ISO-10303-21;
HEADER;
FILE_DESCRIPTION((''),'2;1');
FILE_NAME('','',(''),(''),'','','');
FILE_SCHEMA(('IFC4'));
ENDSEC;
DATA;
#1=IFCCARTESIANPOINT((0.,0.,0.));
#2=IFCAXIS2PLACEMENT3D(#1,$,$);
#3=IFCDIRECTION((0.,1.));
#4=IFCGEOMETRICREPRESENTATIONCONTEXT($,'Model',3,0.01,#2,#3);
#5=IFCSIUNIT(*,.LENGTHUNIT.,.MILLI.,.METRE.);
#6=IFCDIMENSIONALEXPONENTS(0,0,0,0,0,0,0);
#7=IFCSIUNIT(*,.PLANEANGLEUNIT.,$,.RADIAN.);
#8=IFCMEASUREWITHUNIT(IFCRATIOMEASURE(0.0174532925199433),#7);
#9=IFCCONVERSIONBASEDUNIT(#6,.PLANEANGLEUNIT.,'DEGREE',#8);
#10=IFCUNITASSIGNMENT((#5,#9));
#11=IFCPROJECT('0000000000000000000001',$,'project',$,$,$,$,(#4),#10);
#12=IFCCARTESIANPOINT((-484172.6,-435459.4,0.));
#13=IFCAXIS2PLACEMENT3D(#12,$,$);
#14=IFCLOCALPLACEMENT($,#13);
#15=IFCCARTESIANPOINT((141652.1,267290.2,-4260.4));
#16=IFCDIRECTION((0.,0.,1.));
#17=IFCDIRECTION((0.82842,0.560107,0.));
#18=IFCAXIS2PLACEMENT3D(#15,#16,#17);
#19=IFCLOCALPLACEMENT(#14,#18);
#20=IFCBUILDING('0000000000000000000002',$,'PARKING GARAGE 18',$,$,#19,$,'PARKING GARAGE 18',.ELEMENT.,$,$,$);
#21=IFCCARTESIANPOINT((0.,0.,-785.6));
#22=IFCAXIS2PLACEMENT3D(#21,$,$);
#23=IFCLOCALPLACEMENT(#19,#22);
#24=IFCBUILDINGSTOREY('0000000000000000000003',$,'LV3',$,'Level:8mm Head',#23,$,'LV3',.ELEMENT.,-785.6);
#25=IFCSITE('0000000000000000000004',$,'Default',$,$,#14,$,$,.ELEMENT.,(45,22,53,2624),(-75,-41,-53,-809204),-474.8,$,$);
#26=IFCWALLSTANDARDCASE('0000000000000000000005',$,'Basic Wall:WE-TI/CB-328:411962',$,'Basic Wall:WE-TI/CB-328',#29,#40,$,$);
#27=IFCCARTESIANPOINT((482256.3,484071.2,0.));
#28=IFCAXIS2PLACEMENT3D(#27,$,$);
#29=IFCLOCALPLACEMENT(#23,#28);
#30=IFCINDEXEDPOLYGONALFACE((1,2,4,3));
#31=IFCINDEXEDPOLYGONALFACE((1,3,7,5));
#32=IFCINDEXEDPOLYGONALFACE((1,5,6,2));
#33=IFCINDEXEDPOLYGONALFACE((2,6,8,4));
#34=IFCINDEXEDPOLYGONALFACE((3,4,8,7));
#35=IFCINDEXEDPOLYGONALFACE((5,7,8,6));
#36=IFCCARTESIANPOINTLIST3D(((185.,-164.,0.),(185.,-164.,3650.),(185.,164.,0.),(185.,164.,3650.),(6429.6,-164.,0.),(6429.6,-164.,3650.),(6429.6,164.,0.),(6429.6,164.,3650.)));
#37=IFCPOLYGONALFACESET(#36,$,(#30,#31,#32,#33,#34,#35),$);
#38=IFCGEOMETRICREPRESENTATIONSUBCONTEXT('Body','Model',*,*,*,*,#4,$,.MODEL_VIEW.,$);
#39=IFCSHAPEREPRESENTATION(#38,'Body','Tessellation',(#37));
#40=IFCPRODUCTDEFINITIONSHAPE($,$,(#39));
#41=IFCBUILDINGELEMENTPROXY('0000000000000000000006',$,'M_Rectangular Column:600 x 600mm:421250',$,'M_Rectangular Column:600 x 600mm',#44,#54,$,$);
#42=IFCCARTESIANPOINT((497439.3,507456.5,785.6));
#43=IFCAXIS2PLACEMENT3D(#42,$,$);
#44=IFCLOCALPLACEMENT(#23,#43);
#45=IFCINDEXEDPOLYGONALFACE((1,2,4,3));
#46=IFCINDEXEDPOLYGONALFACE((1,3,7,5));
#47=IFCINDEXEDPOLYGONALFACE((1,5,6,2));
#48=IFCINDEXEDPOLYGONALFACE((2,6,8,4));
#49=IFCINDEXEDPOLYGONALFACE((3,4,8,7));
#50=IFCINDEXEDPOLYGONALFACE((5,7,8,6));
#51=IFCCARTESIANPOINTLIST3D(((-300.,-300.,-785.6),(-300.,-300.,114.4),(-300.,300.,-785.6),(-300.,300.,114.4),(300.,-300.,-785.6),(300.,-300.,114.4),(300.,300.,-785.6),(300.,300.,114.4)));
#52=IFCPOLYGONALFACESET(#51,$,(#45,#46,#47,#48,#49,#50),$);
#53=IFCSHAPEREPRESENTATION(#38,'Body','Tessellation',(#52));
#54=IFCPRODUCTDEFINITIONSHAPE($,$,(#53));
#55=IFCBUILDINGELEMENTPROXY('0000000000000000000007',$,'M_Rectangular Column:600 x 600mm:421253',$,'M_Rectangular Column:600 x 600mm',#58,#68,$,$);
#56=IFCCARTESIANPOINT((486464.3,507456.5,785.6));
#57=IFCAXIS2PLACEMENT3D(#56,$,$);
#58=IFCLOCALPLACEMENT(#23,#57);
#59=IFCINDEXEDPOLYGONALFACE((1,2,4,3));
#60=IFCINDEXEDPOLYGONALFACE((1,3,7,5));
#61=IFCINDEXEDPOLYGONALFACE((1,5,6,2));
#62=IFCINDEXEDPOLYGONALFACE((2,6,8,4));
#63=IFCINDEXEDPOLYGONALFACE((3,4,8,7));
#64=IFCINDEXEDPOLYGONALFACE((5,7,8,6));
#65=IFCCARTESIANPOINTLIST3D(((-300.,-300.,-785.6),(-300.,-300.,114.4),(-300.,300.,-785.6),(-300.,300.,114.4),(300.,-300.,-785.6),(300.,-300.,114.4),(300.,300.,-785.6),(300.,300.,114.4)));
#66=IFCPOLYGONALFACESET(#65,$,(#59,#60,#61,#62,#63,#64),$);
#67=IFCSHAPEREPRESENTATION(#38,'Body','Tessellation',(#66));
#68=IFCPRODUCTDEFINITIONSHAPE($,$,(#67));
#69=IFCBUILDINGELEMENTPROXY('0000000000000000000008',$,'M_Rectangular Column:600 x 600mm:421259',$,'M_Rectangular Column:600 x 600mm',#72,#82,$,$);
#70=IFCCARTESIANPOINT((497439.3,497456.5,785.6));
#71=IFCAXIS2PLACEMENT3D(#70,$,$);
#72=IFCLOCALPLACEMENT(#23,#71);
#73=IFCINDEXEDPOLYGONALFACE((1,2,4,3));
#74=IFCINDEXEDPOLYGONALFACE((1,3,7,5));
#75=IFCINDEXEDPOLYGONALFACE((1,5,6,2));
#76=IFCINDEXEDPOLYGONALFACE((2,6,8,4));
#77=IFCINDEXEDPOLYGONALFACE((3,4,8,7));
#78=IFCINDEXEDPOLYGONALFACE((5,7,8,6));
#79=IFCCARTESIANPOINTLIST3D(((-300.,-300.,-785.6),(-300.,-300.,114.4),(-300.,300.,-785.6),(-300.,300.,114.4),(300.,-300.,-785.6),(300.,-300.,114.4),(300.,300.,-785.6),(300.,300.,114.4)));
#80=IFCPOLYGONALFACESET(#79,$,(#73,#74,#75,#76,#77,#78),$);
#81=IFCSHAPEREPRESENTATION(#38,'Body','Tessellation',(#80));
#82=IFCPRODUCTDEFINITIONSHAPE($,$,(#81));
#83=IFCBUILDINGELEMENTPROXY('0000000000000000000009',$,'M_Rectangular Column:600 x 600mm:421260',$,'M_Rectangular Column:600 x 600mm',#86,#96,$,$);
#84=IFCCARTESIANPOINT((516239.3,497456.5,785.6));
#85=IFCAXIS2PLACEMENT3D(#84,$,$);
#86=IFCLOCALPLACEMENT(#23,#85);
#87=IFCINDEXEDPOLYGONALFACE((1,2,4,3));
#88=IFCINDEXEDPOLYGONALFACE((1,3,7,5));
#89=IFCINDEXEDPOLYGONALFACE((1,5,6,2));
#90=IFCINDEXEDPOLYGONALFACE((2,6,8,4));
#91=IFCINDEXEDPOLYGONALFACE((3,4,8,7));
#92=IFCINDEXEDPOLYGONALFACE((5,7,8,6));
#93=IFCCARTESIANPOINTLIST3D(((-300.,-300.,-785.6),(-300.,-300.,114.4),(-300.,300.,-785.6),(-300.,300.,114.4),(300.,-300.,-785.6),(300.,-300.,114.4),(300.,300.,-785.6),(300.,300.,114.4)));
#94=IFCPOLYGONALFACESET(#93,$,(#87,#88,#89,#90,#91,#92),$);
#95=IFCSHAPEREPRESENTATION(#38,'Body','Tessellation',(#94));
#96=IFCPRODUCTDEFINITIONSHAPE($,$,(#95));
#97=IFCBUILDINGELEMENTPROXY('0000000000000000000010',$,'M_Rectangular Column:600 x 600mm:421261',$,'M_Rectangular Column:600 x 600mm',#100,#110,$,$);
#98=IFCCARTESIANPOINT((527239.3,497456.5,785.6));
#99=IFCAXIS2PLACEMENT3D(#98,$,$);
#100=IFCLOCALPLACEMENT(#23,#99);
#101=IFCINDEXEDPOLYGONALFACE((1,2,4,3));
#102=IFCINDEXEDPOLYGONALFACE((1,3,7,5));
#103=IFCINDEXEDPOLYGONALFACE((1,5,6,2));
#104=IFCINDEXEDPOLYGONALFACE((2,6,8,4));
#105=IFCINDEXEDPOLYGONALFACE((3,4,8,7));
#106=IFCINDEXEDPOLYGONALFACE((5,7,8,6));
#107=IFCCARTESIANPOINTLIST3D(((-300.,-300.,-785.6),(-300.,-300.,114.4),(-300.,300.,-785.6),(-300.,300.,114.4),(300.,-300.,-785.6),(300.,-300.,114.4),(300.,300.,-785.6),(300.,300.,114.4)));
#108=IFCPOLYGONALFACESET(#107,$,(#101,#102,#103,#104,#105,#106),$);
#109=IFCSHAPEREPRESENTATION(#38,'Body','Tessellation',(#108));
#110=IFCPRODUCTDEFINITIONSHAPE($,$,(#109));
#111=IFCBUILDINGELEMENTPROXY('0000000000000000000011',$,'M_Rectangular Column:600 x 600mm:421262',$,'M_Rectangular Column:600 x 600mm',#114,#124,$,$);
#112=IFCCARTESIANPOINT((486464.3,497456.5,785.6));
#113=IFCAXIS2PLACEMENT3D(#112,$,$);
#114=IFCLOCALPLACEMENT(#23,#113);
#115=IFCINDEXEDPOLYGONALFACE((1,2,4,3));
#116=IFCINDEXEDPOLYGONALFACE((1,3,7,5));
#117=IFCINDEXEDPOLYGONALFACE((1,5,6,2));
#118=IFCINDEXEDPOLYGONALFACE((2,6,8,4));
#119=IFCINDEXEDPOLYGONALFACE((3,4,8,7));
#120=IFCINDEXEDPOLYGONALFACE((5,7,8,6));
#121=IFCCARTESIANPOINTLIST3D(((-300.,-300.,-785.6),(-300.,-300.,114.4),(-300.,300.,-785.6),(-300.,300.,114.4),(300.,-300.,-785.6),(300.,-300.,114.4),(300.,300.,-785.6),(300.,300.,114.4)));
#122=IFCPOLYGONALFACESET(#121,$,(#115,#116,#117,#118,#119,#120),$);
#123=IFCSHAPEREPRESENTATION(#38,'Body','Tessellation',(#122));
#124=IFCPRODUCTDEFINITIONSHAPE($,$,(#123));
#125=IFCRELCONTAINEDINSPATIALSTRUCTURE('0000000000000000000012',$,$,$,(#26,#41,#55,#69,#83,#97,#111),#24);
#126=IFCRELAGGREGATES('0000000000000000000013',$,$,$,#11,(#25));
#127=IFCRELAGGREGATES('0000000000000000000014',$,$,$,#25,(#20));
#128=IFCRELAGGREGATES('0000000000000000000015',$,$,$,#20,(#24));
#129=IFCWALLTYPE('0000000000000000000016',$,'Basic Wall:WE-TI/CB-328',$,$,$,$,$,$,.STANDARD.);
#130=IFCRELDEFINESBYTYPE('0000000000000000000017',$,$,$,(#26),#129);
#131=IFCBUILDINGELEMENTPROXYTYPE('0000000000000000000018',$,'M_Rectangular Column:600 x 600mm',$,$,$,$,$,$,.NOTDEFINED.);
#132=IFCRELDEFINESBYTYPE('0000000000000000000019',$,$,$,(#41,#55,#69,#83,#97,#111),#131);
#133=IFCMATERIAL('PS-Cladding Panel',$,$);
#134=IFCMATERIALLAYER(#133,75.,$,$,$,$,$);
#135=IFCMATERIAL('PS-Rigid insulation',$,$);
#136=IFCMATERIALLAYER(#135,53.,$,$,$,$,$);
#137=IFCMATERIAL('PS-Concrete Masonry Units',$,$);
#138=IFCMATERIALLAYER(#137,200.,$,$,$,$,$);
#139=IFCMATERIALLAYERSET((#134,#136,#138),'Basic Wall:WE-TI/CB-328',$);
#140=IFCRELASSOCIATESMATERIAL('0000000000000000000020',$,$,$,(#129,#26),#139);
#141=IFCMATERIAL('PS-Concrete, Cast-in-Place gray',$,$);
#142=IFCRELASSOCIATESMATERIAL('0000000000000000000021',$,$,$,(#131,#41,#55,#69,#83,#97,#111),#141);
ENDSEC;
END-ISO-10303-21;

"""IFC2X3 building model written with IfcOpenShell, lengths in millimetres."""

from ifc_helpers import new_model, entity, si_unit, converted_unit, direction, frame, frame_2d, origin, origin_2d_with_axis, place, context, subcontext, project, spatial, rectangle, extrude, source, transform, mapped, material, layer, layer_set, layer_usage, type_object, type_shapes, element, save


model = new_model("IFC2X3")

# Units and contexts
model_context = context("Model", 3, precision=0.01, world=origin(), true_north=direction((0.0, 1.0)))
body_context = subcontext(model_context, "Body", "Model", "MODEL_VIEW")
ifc_project = project(units=[si_unit("LENGTHUNIT", "METRE", prefix="MILLI"), converted_unit("PLANEANGLEUNIT", "DEGREE", entity("IfcRatioMeasure", 0.0174532925199433), si_unit("PLANEANGLEUNIT", "RADIAN"), dimensions=[0, 0, 0, 0, 0, 0, 0])], contexts=[model_context])

# Site, building, storey
site_placement = place(None, frame((-484172.6, -435459.4, 0.0)))
site = spatial("IfcSite", under=ifc_project, at=site_placement, Name="Default", CompositionType="ELEMENT", RefLatitude=(45, 22, 53, 2624), RefLongitude=(-75, -41, -53, -809204), RefElevation=-474.8)
building_placement = place(site_placement, frame((141652.1, 267290.2, -4260.4), z_axis=(0.0, 0.0, 1.0), x_axis=(0.82842, 0.560107, 0.0)))
building = spatial("IfcBuilding", under=site, at=building_placement, Name="PARKING GARAGE 18", LongName="PARKING GARAGE 18", CompositionType="ELEMENT")
storey_placement = place(building_placement, frame((0.0, 0.0, -785.6)))
storey = spatial("IfcBuildingStorey", under=building, at=storey_placement, Name="LV3", ObjectType="Level:8mm Head", LongName="LV3", CompositionType="ELEMENT", Elevation=-785.6)

# Wall
ifc_material_1 = material(Name="PS-Cladding Panel")
ifc_layer_1 = layer(ifc_material_1, 75.0)
ifc_material_2 = material(Name="PS-Rigid insulation")
ifc_layer_2 = layer(ifc_material_2, 53.0)
ifc_material_3 = material(Name="PS-Concrete Masonry Units")
ifc_layer_3 = layer(ifc_material_3, 200.0)
ifc_layer_set_1 = layer_set([ifc_layer_1, ifc_layer_2, ifc_layer_3], Name="Basic Wall:WE-TI/CB-328")
wall_type_1 = type_object("IfcWallType", Name="Basic Wall:WE-TI/CB-328", PredefinedType="STANDARD", material=ifc_layer_set_1)
ifc_layer_usage_1 = layer_usage(ifc_layer_set_1, "AXIS2", "NEGATIVE", 164.0)
wall_1_placement = place(storey_placement, frame((482256.3, 484071.2, 0.0)))
element("IfcWallStandardCase", 1, at=wall_1_placement, inside=storey, type_object=wall_type_1, material=ifc_layer_usage_1, Name="Basic Wall:WE-TI/CB-328:411962", ObjectType="Basic Wall:WE-TI/CB-328", context=body_context, shape_type="SweptSolid", body=[
    extrude(rectangle(XDim=6244.6, YDim=328.0, at=frame_2d((3307.3, 0.0), x_axis=(-1.0, 0.0))), origin(), (0.0, 0.0, 1.0), 3650.0),
])
ifc_material_4 = material(Name="PS-Concrete, Cast-in-Place gray")

# Building element proxies
building_element_proxy_type = type_object("IfcBuildingElementProxyType", Name="M_Rectangular Column:600 x 600mm", PredefinedType="NOTDEFINED", material=ifc_material_4)
shared_shape_1 = source(origin(), body_context, "Body", "SweptSolid", [
    extrude(rectangle(XDim=600.0, YDim=600.0, at=origin_2d_with_axis()), frame((0.0, 0.0, -785.6), z_axis=(0.0, 0.0, 1.0), x_axis=(-1.0, 0.0, 0.0)), (0.0, 0.0, 1.0), 900.0),
])
type_shapes(building_element_proxy_type, [shared_shape_1])
for number, where, name in (
    (2, (497439.3, 507456.5, 785.6), "M_Rectangular Column:600 x 600mm:421250"),
    (3, (486464.3, 507456.5, 785.6), "M_Rectangular Column:600 x 600mm:421253"),
    (4, (497439.3, 497456.5, 785.6), "M_Rectangular Column:600 x 600mm:421259"),
    (5, (516239.3, 497456.5, 785.6), "M_Rectangular Column:600 x 600mm:421260"),
    (6, (527239.3, 497456.5, 785.6), "M_Rectangular Column:600 x 600mm:421261"),
    (7, (486464.3, 497456.5, 785.6), "M_Rectangular Column:600 x 600mm:421262"),
):
    element("IfcBuildingElementProxy", number, at=place(storey_placement, frame(where)), inside=storey, type_object=building_element_proxy_type, material=ifc_material_4, Name=name, ObjectType="M_Rectangular Column:600 x 600mm", context=body_context, shape_type="MappedRepresentation", body=[
        mapped(shared_shape_1, transform((0.0, 0.0, 0.0), scale=1.0)),
    ])

save(model, "model.ifc")
